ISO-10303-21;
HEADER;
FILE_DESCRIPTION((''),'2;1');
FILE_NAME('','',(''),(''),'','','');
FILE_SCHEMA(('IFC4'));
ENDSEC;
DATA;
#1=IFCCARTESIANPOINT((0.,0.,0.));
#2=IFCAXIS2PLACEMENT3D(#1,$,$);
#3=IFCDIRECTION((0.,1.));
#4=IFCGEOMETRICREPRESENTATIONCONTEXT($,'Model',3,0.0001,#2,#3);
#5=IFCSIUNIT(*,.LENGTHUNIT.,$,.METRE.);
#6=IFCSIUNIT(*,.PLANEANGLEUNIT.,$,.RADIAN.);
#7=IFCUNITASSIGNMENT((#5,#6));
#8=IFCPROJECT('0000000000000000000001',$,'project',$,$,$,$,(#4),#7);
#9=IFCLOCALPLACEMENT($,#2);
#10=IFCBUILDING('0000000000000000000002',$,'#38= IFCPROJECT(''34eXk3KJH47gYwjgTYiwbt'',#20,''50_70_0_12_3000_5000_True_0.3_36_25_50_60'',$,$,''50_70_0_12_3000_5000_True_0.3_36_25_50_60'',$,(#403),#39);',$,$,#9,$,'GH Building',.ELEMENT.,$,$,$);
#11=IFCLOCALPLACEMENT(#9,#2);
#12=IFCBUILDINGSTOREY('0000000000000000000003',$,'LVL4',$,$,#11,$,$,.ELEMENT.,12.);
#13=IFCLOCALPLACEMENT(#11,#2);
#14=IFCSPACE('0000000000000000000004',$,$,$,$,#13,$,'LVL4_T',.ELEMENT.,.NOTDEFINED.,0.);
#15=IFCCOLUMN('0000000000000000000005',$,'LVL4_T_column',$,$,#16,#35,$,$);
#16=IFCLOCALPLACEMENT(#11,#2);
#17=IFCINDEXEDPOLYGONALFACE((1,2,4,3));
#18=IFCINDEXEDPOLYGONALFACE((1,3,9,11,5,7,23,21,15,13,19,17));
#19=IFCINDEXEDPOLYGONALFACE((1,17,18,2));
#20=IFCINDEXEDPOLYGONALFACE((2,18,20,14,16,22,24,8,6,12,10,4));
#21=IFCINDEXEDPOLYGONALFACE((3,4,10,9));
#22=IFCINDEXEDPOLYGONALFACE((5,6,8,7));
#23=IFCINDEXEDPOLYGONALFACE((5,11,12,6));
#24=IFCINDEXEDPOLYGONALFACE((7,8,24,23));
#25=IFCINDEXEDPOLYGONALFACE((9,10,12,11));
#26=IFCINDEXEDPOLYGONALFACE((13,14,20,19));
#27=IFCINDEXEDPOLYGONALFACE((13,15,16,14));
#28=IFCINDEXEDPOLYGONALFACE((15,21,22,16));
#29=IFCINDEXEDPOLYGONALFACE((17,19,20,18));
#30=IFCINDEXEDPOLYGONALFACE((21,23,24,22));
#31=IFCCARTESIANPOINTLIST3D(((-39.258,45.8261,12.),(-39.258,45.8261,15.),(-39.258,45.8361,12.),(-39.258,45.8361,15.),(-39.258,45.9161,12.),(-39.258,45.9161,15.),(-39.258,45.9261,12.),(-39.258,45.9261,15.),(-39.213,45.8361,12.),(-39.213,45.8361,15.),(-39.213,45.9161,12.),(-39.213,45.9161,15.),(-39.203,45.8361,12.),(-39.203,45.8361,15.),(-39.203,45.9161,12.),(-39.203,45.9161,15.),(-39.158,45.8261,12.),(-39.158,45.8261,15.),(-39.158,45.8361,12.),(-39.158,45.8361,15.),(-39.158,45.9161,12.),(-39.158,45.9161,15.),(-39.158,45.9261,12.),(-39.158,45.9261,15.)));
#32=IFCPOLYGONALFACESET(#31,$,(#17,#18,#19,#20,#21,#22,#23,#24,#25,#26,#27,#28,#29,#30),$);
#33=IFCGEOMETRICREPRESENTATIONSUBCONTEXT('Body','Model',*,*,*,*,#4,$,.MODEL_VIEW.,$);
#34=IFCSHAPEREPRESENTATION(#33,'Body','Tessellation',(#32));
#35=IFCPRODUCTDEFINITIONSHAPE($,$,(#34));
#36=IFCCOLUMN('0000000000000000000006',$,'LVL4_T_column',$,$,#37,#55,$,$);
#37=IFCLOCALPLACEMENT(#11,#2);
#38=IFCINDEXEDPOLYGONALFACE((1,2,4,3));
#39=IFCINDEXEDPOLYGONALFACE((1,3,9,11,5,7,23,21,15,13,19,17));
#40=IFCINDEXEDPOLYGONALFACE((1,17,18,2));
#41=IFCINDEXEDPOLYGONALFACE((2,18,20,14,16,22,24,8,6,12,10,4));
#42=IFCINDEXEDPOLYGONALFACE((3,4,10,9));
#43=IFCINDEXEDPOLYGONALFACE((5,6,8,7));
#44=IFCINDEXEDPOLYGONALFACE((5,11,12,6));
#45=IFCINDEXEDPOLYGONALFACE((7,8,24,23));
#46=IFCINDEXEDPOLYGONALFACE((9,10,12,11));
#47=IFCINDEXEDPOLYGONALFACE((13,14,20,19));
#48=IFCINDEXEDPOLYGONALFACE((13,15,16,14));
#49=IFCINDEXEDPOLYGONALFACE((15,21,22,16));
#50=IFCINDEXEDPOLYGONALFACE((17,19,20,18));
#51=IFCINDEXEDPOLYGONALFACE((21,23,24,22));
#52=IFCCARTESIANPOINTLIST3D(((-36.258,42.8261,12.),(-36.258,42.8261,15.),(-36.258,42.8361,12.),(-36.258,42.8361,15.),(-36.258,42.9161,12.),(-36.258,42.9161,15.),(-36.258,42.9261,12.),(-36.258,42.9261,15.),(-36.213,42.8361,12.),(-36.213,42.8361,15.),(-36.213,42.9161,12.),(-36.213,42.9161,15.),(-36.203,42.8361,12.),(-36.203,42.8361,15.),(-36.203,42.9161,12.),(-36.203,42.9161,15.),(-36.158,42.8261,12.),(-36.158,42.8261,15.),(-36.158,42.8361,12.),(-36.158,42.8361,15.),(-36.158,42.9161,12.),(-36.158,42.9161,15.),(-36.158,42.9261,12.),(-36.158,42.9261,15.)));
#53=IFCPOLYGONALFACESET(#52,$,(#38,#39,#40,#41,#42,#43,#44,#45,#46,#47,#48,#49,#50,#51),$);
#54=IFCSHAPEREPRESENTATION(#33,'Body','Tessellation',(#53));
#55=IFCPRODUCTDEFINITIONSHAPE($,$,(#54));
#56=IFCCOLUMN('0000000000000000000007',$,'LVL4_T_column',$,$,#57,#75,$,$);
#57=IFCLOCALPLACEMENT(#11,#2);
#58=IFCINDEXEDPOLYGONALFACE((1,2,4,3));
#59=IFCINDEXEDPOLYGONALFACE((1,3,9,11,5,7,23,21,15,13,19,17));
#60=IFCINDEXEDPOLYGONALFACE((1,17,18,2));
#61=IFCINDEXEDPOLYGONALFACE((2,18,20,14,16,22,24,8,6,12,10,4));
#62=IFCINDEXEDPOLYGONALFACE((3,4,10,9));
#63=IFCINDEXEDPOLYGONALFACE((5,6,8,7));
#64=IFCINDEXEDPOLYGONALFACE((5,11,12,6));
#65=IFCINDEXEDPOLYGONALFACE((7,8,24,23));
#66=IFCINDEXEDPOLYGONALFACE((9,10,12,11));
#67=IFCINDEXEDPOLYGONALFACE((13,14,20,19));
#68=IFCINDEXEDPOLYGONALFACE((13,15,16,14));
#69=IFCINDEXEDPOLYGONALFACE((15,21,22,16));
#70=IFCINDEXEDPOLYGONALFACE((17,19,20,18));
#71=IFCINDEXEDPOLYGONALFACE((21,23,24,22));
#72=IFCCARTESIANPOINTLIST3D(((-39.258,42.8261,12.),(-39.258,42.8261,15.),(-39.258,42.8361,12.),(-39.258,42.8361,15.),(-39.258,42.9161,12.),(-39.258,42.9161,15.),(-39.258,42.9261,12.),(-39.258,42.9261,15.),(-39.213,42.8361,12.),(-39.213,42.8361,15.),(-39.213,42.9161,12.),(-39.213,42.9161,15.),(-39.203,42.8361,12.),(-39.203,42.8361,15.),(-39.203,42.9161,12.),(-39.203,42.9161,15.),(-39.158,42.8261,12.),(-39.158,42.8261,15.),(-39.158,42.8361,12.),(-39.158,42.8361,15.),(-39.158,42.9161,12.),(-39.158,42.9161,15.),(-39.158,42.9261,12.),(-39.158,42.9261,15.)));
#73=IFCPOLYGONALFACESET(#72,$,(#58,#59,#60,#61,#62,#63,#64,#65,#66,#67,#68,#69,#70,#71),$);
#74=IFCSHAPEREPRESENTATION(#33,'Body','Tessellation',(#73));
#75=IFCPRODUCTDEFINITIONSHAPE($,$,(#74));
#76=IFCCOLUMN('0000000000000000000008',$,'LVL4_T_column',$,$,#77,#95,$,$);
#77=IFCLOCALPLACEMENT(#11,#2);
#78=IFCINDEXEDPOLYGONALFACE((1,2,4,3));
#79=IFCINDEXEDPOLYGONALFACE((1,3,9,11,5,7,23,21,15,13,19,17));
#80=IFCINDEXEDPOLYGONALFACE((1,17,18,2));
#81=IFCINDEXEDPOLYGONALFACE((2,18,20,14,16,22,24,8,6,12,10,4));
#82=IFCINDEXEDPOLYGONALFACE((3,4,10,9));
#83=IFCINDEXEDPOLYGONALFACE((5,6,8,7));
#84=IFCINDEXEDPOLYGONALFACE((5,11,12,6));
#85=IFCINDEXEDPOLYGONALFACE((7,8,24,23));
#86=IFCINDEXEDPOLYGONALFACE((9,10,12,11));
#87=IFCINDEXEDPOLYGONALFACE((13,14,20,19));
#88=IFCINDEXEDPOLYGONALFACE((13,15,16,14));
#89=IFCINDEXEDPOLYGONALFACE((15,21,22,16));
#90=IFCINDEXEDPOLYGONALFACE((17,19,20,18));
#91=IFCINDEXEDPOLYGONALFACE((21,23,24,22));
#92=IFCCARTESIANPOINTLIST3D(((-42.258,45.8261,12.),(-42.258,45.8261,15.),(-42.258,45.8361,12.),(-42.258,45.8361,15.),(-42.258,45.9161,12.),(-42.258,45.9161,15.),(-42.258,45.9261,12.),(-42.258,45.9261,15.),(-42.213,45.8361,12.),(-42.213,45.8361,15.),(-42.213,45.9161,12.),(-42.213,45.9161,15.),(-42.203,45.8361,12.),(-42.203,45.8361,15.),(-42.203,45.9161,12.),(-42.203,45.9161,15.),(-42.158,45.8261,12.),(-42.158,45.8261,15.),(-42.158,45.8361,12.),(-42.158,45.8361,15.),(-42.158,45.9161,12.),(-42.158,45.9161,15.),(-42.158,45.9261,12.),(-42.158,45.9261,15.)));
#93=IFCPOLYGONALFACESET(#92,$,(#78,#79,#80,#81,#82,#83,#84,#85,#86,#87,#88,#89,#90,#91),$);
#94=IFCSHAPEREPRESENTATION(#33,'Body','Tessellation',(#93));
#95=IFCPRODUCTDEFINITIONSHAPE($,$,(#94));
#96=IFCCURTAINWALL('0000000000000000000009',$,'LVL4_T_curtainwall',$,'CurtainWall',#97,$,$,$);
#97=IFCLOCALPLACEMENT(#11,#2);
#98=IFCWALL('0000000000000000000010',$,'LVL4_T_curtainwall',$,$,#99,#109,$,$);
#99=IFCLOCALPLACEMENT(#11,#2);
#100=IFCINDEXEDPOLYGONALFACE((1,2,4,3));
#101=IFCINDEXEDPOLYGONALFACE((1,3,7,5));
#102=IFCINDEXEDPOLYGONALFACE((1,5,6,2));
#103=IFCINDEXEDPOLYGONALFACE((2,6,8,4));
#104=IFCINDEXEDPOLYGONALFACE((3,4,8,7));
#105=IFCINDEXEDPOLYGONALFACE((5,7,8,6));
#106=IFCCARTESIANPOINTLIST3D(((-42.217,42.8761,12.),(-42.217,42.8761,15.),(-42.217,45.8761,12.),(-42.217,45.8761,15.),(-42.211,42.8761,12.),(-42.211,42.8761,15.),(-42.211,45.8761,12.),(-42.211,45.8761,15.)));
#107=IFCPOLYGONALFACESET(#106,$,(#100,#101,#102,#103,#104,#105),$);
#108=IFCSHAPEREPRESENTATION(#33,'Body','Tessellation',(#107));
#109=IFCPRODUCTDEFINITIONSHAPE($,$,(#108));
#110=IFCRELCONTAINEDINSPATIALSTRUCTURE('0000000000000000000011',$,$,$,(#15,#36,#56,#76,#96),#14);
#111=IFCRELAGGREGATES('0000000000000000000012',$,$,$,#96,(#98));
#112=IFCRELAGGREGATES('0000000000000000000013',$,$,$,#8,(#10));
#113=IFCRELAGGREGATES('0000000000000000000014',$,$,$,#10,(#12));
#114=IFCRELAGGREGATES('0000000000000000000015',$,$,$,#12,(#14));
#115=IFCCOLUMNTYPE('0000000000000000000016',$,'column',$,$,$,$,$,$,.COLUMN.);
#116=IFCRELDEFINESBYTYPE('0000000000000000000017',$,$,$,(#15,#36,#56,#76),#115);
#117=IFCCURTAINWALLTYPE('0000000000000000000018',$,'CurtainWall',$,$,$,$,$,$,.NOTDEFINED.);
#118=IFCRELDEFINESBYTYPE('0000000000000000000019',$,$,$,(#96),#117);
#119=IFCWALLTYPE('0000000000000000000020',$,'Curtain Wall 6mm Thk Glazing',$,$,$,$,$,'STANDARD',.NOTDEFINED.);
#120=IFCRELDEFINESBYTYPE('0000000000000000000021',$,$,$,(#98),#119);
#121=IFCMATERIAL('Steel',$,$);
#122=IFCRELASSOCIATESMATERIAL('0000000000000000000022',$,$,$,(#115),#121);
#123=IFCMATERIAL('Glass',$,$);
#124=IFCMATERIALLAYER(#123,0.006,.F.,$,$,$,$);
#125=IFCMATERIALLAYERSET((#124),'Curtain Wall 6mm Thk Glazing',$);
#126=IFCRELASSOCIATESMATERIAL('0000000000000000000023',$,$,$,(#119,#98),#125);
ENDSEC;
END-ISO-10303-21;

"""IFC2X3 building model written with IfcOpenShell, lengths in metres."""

from ifc_helpers import new_model, si_unit, direction, frame, frame_2d, origin, origin_2d, place, context, subcontext, project, spatial, rectangle, i_section, extrude, material, layer, layer_set, layer_usage, type_object, element, aggregate, save


model = new_model("IFC2X3")

# Units and contexts
model_context = context("Model", 3, precision=0.0001, world=origin(), true_north=direction((0.0, 1.0)))
body_context = subcontext(model_context, "Body", "Model", "MODEL_VIEW")
ifc_project = project(units=[si_unit("LENGTHUNIT", "METRE"), si_unit("PLANEANGLEUNIT", "RADIAN")], contexts=[model_context])

# Building, storey, space
building_placement = place(None, origin())
building = spatial("IfcBuilding", under=ifc_project, at=building_placement, Name="#38= IFCPROJECT('34eXk3KJH47gYwjgTYiwbt',#20,'50_70_0_12_3000_5000_True_0.3_36_25_50_60',$,$,'50_70_0_12_3000_5000_True_0.3_36_25_50_60',$,(#403),#39);", LongName="GH Building", CompositionType="ELEMENT")
storey_placement = place(building_placement, origin())
storey = spatial("IfcBuildingStorey", under=building, at=storey_placement, Name="LVL4", CompositionType="ELEMENT", Elevation=12.0)
space_placement = place(storey_placement, origin())
space = spatial("IfcSpace", under=storey, at=space_placement, LongName="LVL4_T", CompositionType="ELEMENT", InteriorOrExteriorSpace="NOTDEFINED", ElevationWithFlooring=0.0)

# Columns
ifc_material_1 = material(Name="Steel")
column_type = type_object("IfcColumnType", Name="column", PredefinedType="COLUMN", material=ifc_material_1)
for number, where, name in (
    (1, (-39.208, 45.8761, 12.0), "LVL4_T_column"),
    (2, (-36.208, 42.8761, 12.0), "LVL4_T_column"),
    (3, (-39.208, 42.8761, 12.0), "LVL4_T_column"),
    (4, (-42.208, 45.8761, 12.0), "LVL4_T_column"),
):
    element("IfcColumn", number, at=place(space_placement, frame(where)), inside=space, type_object=column_type, Name=name, context=body_context, shape_type="SweptSolid", body=[
        extrude(i_section(OverallWidth=0.1, OverallDepth=0.1, WebThickness=0.01, FlangeThickness=0.01, at=origin_2d()), origin(), (0.0, 0.0, 1.0), 3.0),
    ])

# Curtain wall, wall
curtain_wall_type = type_object("IfcCurtainWallType", Name="CurtainWall", PredefinedType="NOTDEFINED")
curtain_wall_placement = place(None, origin())
curtain_wall = element("IfcCurtainWall", 5, at=curtain_wall_placement, inside=space, type_object=curtain_wall_type, Name="LVL4_T_curtainwall", ObjectType="CurtainWall")
ifc_material_2 = material(Name="Glass")
ifc_layer = layer(ifc_material_2, 0.006, ventilated=False)
ifc_layer_set = layer_set([ifc_layer], Name="Curtain Wall 6mm Thk Glazing")
ifc_layer_usage_1 = layer_usage(ifc_layer_set, "AXIS2", "NEGATIVE", -0.003)
wall_type = type_object("IfcWallType", Name="Curtain Wall 6mm Thk Glazing", ElementType="STANDARD", PredefinedType="NOTDEFINED", material=ifc_layer_set)
wall_1_placement = place(curtain_wall_placement, frame((-42.208, 45.8761, 12.0), z_axis=(0.0, 0.0, 1.0), x_axis=(0.0, -1.0, 0.0)))
wall_1 = element("IfcWall", 6, at=wall_1_placement, type_object=wall_type, material=ifc_layer_usage_1, Name="LVL4_T_curtainwall", context=body_context, shape_type="SweptSolid", body=[
    extrude(rectangle(XDim=3.0, YDim=0.006, at=frame_2d((1.5, -0.006))), origin(), (0.0, 0.0, 1.0), 3.0),
])
aggregate(curtain_wall, [wall_1])

save(model, "model.ifc")
